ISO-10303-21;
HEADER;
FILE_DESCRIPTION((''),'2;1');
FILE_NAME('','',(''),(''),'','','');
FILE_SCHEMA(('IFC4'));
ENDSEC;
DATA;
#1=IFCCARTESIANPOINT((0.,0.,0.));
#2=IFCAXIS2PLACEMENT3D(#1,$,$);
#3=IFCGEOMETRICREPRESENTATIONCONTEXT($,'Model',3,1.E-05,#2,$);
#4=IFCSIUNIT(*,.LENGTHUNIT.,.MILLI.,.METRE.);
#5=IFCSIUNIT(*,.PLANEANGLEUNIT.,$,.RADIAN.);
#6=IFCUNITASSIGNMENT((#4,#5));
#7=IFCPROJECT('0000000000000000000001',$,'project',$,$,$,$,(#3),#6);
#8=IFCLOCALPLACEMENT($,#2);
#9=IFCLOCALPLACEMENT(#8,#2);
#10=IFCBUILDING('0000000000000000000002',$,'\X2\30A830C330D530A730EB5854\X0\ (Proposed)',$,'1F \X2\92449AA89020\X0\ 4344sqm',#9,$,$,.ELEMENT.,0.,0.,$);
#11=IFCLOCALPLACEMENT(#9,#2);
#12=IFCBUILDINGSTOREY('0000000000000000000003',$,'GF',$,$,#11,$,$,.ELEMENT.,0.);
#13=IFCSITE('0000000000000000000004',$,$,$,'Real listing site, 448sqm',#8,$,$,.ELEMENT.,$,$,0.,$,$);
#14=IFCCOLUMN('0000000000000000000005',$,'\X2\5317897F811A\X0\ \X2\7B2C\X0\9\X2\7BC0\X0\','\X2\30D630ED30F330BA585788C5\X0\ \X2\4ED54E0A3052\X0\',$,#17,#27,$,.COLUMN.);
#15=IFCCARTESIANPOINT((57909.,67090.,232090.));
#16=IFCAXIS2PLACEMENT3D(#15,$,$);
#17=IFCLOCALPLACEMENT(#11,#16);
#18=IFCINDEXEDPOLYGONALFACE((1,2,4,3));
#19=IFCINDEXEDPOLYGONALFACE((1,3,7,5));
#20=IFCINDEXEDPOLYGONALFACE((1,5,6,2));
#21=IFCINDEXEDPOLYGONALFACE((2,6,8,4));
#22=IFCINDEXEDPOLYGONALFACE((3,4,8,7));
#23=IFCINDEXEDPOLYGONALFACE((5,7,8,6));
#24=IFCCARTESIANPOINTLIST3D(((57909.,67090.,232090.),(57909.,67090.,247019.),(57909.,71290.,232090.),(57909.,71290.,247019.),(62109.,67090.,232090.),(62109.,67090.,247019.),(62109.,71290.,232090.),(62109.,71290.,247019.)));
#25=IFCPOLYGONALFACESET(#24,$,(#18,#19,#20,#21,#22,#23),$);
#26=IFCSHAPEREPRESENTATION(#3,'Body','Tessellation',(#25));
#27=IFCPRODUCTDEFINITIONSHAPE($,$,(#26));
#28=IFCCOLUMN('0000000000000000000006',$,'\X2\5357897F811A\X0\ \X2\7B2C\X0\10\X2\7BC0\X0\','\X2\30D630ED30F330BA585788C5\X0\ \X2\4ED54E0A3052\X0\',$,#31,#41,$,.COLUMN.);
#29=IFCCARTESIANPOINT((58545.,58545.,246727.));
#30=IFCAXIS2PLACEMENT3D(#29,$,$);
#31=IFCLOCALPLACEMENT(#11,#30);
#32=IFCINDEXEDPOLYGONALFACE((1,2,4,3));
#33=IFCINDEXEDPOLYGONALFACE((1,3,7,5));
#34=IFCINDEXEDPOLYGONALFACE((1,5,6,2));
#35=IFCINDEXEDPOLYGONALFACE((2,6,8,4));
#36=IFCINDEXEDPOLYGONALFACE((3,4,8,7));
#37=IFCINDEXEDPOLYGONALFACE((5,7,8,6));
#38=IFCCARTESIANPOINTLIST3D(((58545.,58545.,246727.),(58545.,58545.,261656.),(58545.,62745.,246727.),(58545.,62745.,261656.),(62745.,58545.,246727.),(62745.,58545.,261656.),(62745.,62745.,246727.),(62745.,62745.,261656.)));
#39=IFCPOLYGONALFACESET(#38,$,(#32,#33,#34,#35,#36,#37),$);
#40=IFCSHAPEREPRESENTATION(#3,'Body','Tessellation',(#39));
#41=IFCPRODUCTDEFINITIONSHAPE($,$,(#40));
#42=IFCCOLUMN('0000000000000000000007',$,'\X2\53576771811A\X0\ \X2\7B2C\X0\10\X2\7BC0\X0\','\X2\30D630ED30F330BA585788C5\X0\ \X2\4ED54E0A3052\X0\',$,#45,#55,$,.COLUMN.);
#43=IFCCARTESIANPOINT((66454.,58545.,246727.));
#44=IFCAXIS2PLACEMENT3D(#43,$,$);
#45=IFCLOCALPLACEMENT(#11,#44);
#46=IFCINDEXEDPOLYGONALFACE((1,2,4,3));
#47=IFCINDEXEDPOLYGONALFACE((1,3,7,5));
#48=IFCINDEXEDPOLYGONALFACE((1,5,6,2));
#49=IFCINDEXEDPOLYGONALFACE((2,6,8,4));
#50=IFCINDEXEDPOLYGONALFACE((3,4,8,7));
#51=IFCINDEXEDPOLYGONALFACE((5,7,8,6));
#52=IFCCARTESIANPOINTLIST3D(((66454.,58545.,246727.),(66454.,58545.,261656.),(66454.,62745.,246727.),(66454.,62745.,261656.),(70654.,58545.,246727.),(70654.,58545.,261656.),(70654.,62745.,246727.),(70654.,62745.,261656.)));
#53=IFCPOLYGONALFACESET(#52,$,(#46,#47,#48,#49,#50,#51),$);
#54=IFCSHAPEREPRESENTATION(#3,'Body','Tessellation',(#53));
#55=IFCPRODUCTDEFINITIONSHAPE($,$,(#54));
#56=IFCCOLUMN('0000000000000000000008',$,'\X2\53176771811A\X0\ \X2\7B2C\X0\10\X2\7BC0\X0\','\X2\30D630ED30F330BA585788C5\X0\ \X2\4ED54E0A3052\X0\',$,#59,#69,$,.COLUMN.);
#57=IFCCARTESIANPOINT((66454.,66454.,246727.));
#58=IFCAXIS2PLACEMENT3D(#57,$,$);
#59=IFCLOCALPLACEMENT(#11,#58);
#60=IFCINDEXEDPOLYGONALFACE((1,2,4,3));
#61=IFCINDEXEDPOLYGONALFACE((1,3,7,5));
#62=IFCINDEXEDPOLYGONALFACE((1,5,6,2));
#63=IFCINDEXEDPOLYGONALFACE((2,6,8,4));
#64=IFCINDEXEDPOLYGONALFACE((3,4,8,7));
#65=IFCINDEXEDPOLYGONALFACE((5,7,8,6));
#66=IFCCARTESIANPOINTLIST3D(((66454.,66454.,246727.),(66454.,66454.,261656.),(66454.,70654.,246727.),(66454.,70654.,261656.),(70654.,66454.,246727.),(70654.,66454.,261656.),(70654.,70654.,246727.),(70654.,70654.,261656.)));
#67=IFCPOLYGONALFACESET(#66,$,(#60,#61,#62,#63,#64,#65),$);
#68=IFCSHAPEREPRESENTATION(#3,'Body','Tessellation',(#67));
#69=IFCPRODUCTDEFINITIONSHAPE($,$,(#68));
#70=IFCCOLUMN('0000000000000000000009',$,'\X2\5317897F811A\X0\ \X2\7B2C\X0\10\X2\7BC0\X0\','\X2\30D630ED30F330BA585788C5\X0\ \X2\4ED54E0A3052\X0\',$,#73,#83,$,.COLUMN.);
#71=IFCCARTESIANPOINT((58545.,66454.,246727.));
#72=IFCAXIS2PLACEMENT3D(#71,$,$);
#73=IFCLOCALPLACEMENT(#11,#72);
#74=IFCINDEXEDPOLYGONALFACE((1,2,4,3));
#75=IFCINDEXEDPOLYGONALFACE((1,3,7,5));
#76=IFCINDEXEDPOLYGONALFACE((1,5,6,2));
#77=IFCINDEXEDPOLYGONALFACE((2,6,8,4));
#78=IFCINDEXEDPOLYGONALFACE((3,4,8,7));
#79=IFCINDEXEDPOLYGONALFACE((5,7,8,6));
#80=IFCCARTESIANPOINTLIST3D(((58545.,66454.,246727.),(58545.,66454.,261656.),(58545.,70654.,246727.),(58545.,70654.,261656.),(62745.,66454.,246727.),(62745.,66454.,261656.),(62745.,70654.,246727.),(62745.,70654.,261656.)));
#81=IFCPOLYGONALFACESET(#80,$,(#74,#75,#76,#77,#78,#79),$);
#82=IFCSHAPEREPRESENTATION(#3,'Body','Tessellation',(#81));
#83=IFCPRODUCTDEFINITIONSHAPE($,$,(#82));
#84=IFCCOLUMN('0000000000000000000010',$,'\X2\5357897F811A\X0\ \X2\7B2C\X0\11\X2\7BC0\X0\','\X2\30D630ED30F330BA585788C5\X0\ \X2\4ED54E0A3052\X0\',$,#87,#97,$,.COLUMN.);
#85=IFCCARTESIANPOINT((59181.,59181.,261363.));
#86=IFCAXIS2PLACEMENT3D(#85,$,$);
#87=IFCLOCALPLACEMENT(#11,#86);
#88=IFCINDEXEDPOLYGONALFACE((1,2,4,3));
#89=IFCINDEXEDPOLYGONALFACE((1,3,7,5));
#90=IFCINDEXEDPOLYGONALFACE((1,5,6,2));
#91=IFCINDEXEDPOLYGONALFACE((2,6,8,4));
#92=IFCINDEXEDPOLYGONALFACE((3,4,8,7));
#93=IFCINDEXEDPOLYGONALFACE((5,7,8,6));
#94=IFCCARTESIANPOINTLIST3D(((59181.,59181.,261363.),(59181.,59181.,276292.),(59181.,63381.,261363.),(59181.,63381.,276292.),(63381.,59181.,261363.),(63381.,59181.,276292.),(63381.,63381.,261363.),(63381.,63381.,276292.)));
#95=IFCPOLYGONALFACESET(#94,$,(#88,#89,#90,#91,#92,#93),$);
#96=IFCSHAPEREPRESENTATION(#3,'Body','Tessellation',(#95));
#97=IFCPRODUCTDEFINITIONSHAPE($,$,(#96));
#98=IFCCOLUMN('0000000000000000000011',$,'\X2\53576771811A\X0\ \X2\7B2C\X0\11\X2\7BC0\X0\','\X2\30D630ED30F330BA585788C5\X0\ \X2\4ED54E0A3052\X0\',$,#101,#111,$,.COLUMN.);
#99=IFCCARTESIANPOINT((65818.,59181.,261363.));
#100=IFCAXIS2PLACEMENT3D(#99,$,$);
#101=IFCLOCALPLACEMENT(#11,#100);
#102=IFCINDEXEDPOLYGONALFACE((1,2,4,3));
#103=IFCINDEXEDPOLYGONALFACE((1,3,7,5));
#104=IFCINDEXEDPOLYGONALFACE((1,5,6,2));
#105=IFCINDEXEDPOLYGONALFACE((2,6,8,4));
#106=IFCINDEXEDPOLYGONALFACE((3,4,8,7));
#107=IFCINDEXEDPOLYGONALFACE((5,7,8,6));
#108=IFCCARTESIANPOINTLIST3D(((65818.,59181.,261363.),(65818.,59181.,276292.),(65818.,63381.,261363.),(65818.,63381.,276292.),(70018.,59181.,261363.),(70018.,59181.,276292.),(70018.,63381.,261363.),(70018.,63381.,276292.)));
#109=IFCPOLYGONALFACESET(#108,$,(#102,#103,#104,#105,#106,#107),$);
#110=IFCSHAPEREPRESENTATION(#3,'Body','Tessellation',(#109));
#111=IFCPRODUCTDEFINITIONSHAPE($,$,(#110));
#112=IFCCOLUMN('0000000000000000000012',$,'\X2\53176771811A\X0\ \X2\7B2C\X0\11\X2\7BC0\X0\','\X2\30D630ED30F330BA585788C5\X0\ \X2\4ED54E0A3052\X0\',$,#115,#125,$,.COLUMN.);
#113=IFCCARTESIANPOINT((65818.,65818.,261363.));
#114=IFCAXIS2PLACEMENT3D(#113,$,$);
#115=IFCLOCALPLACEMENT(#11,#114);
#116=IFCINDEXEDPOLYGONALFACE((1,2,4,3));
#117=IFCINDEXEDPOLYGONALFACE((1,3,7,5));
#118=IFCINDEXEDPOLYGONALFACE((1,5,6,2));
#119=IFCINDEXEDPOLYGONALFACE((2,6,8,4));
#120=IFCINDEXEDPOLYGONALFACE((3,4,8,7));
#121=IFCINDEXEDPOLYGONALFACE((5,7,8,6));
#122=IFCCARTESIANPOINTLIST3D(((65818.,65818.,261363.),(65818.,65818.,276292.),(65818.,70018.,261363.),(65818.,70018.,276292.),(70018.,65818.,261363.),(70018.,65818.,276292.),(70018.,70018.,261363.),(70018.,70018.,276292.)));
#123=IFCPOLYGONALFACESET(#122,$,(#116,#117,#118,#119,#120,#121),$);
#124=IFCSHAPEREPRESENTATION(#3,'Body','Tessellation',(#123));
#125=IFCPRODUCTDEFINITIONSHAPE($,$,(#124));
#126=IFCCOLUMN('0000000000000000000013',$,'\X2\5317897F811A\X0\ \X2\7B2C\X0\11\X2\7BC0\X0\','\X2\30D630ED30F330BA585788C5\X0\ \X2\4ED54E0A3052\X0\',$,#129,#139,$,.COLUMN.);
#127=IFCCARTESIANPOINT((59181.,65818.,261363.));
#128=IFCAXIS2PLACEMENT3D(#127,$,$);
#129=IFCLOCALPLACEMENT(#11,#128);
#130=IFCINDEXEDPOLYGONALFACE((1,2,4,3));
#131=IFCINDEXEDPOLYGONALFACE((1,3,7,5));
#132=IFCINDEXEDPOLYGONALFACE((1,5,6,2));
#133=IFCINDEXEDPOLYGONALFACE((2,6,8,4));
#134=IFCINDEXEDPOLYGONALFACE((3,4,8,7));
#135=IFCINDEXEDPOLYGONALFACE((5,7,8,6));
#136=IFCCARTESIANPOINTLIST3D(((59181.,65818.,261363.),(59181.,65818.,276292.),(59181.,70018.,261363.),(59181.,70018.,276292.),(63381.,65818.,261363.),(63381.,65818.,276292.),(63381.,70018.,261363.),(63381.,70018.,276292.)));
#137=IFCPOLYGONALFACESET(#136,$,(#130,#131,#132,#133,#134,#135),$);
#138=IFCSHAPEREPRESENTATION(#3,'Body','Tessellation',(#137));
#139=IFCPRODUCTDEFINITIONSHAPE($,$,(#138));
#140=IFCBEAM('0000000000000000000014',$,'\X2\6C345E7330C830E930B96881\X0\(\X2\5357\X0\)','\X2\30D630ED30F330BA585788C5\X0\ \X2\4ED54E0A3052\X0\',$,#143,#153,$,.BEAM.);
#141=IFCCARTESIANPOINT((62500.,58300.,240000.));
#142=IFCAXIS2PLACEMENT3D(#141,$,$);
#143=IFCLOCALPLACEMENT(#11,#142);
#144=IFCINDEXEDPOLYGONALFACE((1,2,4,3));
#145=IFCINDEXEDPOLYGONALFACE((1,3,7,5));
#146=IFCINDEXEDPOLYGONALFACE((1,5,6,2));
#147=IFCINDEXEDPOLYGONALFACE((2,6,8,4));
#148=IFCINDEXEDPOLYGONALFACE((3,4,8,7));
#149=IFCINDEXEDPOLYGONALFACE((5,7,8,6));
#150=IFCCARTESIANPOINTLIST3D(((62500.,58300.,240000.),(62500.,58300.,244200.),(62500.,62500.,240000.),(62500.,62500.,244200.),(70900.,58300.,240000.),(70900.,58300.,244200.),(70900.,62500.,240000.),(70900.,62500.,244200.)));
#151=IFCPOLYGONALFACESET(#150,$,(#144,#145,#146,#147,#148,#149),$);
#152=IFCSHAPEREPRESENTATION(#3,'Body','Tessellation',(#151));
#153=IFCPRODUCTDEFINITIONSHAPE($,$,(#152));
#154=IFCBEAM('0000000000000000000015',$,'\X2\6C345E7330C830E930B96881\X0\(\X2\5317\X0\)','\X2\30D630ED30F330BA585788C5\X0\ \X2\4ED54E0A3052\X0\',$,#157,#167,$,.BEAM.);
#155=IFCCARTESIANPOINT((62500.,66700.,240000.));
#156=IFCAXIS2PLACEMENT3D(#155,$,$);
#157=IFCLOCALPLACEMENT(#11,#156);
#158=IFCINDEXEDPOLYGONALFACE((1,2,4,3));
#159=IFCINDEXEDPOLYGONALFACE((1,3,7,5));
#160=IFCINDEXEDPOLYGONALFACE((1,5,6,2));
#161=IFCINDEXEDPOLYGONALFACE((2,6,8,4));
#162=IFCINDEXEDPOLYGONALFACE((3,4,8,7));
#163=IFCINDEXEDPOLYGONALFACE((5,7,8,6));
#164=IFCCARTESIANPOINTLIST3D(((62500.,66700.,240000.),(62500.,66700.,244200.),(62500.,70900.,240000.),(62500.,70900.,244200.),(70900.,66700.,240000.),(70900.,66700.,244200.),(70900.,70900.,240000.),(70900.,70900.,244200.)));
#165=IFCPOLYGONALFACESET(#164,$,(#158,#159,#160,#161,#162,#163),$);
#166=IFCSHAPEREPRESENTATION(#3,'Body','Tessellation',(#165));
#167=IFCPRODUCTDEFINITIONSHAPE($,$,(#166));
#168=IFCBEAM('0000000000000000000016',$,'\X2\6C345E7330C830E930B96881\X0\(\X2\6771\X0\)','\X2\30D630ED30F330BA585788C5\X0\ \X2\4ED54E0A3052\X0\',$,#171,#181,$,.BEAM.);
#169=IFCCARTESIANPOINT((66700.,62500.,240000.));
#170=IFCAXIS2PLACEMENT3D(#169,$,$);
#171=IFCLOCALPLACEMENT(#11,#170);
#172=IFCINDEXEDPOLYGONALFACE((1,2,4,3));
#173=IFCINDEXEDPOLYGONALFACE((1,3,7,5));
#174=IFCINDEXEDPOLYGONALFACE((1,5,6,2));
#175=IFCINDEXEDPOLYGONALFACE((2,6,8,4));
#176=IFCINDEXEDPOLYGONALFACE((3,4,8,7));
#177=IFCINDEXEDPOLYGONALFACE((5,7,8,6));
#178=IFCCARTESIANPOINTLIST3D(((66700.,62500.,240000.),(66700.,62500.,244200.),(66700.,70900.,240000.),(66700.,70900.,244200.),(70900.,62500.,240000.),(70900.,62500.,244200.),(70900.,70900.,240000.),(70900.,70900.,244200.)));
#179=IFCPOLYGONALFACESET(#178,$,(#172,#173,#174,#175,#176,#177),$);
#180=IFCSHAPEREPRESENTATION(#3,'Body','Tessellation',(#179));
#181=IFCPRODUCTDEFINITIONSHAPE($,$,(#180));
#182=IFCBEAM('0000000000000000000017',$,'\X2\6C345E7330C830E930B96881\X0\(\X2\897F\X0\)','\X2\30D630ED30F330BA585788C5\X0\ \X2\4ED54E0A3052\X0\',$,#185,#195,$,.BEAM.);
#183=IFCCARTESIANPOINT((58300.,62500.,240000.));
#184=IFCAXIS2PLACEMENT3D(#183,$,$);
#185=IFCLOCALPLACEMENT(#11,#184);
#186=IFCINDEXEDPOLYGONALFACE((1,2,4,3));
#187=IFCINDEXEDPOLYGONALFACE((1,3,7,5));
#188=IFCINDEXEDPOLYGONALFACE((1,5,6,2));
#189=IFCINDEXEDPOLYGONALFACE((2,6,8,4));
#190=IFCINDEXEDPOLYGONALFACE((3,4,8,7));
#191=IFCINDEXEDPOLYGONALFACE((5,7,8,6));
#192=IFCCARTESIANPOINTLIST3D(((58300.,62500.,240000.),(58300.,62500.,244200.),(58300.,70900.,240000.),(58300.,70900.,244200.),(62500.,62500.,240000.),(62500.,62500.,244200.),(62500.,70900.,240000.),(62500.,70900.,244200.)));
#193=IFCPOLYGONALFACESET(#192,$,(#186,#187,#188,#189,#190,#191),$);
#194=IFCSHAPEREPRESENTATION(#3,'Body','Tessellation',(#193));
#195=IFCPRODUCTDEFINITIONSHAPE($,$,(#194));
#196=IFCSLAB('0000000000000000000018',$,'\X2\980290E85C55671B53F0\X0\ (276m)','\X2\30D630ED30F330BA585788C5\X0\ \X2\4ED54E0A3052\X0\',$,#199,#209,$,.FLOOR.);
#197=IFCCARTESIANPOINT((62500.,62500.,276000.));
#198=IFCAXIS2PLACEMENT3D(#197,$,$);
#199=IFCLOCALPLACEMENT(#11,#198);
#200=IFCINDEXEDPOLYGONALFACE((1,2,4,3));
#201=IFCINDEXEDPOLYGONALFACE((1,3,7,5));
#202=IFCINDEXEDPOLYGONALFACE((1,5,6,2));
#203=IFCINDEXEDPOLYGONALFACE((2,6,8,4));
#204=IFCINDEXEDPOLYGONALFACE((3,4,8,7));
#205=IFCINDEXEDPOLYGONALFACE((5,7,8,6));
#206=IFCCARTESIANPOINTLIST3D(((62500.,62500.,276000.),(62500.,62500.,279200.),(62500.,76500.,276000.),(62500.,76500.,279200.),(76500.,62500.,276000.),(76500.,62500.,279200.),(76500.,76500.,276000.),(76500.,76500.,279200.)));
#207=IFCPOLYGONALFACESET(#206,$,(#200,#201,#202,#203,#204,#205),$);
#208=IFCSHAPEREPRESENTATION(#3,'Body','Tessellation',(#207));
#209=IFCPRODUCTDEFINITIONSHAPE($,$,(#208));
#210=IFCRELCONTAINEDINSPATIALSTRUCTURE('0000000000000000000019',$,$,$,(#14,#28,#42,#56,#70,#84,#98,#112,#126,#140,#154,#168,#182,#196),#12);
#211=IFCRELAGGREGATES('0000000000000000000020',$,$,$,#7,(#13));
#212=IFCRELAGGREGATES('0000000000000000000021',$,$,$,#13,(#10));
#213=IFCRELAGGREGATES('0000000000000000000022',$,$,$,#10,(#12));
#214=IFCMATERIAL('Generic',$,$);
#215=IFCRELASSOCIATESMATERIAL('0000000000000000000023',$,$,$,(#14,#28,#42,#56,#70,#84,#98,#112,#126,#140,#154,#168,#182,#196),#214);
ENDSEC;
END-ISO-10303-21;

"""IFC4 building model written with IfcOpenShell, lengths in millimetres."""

from ifc_helpers import new_model, si_unit, frame, frame_2d, origin, place, context, project, spatial, rectangle, extrude, material, element, save


model = new_model("IFC4")

# Units and contexts
model_context = context("Model", 3, precision=1e-05, world=origin())
ifc_project = project(units=[si_unit("LENGTHUNIT", "METRE", prefix="MILLI"), si_unit("PLANEANGLEUNIT", "RADIAN")], contexts=[model_context])

# Site, building, storey
site_placement = place(None, origin())
site = spatial("IfcSite", under=ifc_project, at=site_placement, ObjectType="Real listing site, 448sqm", CompositionType="ELEMENT", RefElevation=0.0)
building_placement = place(site_placement, origin())
building = spatial("IfcBuilding", under=site, at=building_placement, Name="エッフェル塔 (Proposed)", ObjectType="1F 鉄骨造 4344sqm", CompositionType="ELEMENT", ElevationOfRefHeight=0.0, ElevationOfTerrain=0.0)
storey_placement = place(building_placement, origin())
storey = spatial("IfcBuildingStorey", under=building, at=storey_placement, Name="GF", CompositionType="ELEMENT", Elevation=0.0)

# Columns
ifc_material_1 = material(Name="Generic")
column_1_placement = place(storey_placement, frame((57909.0, 67090.0, 232090.0)))
element("IfcColumn", 1, at=column_1_placement, inside=storey, material=ifc_material_1, Name="北西脚 第9節", Description="ブロンズ塗装 仕上げ", PredefinedType="COLUMN", context=model_context, shape_type="SweptSolid", body=[
    extrude(rectangle(XDim=4200.0, YDim=4200.0, at=frame_2d((2100.0, 2100.0))), frame((57909.0, 67090.0, 232090.0)), (0.0, 0.0, 1.0), 14929.0),
])
column_2_placement = place(storey_placement, frame((58545.0, 58545.0, 246727.0)))
element("IfcColumn", 2, at=column_2_placement, inside=storey, material=ifc_material_1, Name="南西脚 第10節", Description="ブロンズ塗装 仕上げ", PredefinedType="COLUMN", context=model_context, shape_type="SweptSolid", body=[
    extrude(rectangle(XDim=4200.0, YDim=4200.0, at=frame_2d((2100.0, 2100.0))), frame((58545.0, 58545.0, 246727.0)), (0.0, 0.0, 1.0), 14929.0),
])
column_3_placement = place(storey_placement, frame((66454.0, 58545.0, 246727.0)))
element("IfcColumn", 3, at=column_3_placement, inside=storey, material=ifc_material_1, Name="南東脚 第10節", Description="ブロンズ塗装 仕上げ", PredefinedType="COLUMN", context=model_context, shape_type="SweptSolid", body=[
    extrude(rectangle(XDim=4200.0, YDim=4200.0, at=frame_2d((2100.0, 2100.0))), frame((66454.0, 58545.0, 246727.0)), (0.0, 0.0, 1.0), 14929.0),
])
column_4_placement = place(storey_placement, frame((66454.0, 66454.0, 246727.0)))
element("IfcColumn", 4, at=column_4_placement, inside=storey, material=ifc_material_1, Name="北東脚 第10節", Description="ブロンズ塗装 仕上げ", PredefinedType="COLUMN", context=model_context, shape_type="SweptSolid", body=[
    extrude(rectangle(XDim=4200.0, YDim=4200.0, at=frame_2d((2100.0, 2100.0))), frame((66454.0, 66454.0, 246727.0)), (0.0, 0.0, 1.0), 14929.0),
])
column_5_placement = place(storey_placement, frame((58545.0, 66454.0, 246727.0)))
element("IfcColumn", 5, at=column_5_placement, inside=storey, material=ifc_material_1, Name="北西脚 第10節", Description="ブロンズ塗装 仕上げ", PredefinedType="COLUMN", context=model_context, shape_type="SweptSolid", body=[
    extrude(rectangle(XDim=4200.0, YDim=4200.0, at=frame_2d((2100.0, 2100.0))), frame((58545.0, 66454.0, 246727.0)), (0.0, 0.0, 1.0), 14929.0),
])
column_6_placement = place(storey_placement, frame((59181.0, 59181.0, 261363.0)))
element("IfcColumn", 6, at=column_6_placement, inside=storey, material=ifc_material_1, Name="南西脚 第11節", Description="ブロンズ塗装 仕上げ", PredefinedType="COLUMN", context=model_context, shape_type="SweptSolid", body=[
    extrude(rectangle(XDim=4200.0, YDim=4200.0, at=frame_2d((2100.0, 2100.0))), frame((59181.0, 59181.0, 261363.0)), (0.0, 0.0, 1.0), 14929.0),
])
column_7_placement = place(storey_placement, frame((65818.0, 59181.0, 261363.0)))
element("IfcColumn", 7, at=column_7_placement, inside=storey, material=ifc_material_1, Name="南東脚 第11節", Description="ブロンズ塗装 仕上げ", PredefinedType="COLUMN", context=model_context, shape_type="SweptSolid", body=[
    extrude(rectangle(XDim=4200.0, YDim=4200.0, at=frame_2d((2100.0, 2100.0))), frame((65818.0, 59181.0, 261363.0)), (0.0, 0.0, 1.0), 14929.0),
])
column_8_placement = place(storey_placement, frame((65818.0, 65818.0, 261363.0)))
element("IfcColumn", 8, at=column_8_placement, inside=storey, material=ifc_material_1, Name="北東脚 第11節", Description="ブロンズ塗装 仕上げ", PredefinedType="COLUMN", context=model_context, shape_type="SweptSolid", body=[
    extrude(rectangle(XDim=4200.0, YDim=4200.0, at=frame_2d((2100.0, 2100.0))), frame((65818.0, 65818.0, 261363.0)), (0.0, 0.0, 1.0), 14929.0),
])
column_9_placement = place(storey_placement, frame((59181.0, 65818.0, 261363.0)))
element("IfcColumn", 9, at=column_9_placement, inside=storey, material=ifc_material_1, Name="北西脚 第11節", Description="ブロンズ塗装 仕上げ", PredefinedType="COLUMN", context=model_context, shape_type="SweptSolid", body=[
    extrude(rectangle(XDim=4200.0, YDim=4200.0, at=frame_2d((2100.0, 2100.0))), frame((59181.0, 65818.0, 261363.0)), (0.0, 0.0, 1.0), 14929.0),
])

# Beams
beam_1_placement = place(storey_placement, frame((62500.0, 58300.0, 240000.0)))
element("IfcBeam", 10, at=beam_1_placement, inside=storey, material=ifc_material_1, Name="水平トラス梁(南)", Description="ブロンズ塗装 仕上げ", PredefinedType="BEAM", context=model_context, shape_type="SweptSolid", body=[
    extrude(rectangle(XDim=8400.0, YDim=4200.0, at=frame_2d((4200.0, 2100.0))), frame((62500.0, 58300.0, 240000.0)), (0.0, 0.0, 1.0), 4200.0),
])
beam_2_placement = place(storey_placement, frame((62500.0, 66700.0, 240000.0)))
element("IfcBeam", 11, at=beam_2_placement, inside=storey, material=ifc_material_1, Name="水平トラス梁(北)", Description="ブロンズ塗装 仕上げ", PredefinedType="BEAM", context=model_context, shape_type="SweptSolid", body=[
    extrude(rectangle(XDim=8400.0, YDim=4200.0, at=frame_2d((4200.0, 2100.0))), frame((62500.0, 66700.0, 240000.0)), (0.0, 0.0, 1.0), 4200.0),
])
beam_3_placement = place(storey_placement, frame((66700.0, 62500.0, 240000.0)))
element("IfcBeam", 12, at=beam_3_placement, inside=storey, material=ifc_material_1, Name="水平トラス梁(東)", Description="ブロンズ塗装 仕上げ", PredefinedType="BEAM", context=model_context, shape_type="SweptSolid", body=[
    extrude(rectangle(XDim=4200.0, YDim=8400.0, at=frame_2d((2100.0, 4200.0))), frame((66700.0, 62500.0, 240000.0)), (0.0, 0.0, 1.0), 4200.0),
])
beam_4_placement = place(storey_placement, frame((58300.0, 62500.0, 240000.0)))
element("IfcBeam", 13, at=beam_4_placement, inside=storey, material=ifc_material_1, Name="水平トラス梁(西)", Description="ブロンズ塗装 仕上げ", PredefinedType="BEAM", context=model_context, shape_type="SweptSolid", body=[
    extrude(rectangle(XDim=4200.0, YDim=8400.0, at=frame_2d((2100.0, 4200.0))), frame((58300.0, 62500.0, 240000.0)), (0.0, 0.0, 1.0), 4200.0),
])

# Slab
slab_placement = place(storey_placement, frame((62500.0, 62500.0, 276000.0)))
element("IfcSlab", 14, at=slab_placement, inside=storey, material=ifc_material_1, Name="頂部展望台 (276m)", Description="ブロンズ塗装 仕上げ", PredefinedType="FLOOR", context=model_context, shape_type="SweptSolid", body=[
    extrude(rectangle(XDim=14000.0, YDim=14000.0, at=frame_2d((7000.0, 7000.0))), frame((62500.0, 62500.0, 276000.0)), (0.0, 0.0, 1.0), 3200.0),
])

save(model, "model.ifc")
